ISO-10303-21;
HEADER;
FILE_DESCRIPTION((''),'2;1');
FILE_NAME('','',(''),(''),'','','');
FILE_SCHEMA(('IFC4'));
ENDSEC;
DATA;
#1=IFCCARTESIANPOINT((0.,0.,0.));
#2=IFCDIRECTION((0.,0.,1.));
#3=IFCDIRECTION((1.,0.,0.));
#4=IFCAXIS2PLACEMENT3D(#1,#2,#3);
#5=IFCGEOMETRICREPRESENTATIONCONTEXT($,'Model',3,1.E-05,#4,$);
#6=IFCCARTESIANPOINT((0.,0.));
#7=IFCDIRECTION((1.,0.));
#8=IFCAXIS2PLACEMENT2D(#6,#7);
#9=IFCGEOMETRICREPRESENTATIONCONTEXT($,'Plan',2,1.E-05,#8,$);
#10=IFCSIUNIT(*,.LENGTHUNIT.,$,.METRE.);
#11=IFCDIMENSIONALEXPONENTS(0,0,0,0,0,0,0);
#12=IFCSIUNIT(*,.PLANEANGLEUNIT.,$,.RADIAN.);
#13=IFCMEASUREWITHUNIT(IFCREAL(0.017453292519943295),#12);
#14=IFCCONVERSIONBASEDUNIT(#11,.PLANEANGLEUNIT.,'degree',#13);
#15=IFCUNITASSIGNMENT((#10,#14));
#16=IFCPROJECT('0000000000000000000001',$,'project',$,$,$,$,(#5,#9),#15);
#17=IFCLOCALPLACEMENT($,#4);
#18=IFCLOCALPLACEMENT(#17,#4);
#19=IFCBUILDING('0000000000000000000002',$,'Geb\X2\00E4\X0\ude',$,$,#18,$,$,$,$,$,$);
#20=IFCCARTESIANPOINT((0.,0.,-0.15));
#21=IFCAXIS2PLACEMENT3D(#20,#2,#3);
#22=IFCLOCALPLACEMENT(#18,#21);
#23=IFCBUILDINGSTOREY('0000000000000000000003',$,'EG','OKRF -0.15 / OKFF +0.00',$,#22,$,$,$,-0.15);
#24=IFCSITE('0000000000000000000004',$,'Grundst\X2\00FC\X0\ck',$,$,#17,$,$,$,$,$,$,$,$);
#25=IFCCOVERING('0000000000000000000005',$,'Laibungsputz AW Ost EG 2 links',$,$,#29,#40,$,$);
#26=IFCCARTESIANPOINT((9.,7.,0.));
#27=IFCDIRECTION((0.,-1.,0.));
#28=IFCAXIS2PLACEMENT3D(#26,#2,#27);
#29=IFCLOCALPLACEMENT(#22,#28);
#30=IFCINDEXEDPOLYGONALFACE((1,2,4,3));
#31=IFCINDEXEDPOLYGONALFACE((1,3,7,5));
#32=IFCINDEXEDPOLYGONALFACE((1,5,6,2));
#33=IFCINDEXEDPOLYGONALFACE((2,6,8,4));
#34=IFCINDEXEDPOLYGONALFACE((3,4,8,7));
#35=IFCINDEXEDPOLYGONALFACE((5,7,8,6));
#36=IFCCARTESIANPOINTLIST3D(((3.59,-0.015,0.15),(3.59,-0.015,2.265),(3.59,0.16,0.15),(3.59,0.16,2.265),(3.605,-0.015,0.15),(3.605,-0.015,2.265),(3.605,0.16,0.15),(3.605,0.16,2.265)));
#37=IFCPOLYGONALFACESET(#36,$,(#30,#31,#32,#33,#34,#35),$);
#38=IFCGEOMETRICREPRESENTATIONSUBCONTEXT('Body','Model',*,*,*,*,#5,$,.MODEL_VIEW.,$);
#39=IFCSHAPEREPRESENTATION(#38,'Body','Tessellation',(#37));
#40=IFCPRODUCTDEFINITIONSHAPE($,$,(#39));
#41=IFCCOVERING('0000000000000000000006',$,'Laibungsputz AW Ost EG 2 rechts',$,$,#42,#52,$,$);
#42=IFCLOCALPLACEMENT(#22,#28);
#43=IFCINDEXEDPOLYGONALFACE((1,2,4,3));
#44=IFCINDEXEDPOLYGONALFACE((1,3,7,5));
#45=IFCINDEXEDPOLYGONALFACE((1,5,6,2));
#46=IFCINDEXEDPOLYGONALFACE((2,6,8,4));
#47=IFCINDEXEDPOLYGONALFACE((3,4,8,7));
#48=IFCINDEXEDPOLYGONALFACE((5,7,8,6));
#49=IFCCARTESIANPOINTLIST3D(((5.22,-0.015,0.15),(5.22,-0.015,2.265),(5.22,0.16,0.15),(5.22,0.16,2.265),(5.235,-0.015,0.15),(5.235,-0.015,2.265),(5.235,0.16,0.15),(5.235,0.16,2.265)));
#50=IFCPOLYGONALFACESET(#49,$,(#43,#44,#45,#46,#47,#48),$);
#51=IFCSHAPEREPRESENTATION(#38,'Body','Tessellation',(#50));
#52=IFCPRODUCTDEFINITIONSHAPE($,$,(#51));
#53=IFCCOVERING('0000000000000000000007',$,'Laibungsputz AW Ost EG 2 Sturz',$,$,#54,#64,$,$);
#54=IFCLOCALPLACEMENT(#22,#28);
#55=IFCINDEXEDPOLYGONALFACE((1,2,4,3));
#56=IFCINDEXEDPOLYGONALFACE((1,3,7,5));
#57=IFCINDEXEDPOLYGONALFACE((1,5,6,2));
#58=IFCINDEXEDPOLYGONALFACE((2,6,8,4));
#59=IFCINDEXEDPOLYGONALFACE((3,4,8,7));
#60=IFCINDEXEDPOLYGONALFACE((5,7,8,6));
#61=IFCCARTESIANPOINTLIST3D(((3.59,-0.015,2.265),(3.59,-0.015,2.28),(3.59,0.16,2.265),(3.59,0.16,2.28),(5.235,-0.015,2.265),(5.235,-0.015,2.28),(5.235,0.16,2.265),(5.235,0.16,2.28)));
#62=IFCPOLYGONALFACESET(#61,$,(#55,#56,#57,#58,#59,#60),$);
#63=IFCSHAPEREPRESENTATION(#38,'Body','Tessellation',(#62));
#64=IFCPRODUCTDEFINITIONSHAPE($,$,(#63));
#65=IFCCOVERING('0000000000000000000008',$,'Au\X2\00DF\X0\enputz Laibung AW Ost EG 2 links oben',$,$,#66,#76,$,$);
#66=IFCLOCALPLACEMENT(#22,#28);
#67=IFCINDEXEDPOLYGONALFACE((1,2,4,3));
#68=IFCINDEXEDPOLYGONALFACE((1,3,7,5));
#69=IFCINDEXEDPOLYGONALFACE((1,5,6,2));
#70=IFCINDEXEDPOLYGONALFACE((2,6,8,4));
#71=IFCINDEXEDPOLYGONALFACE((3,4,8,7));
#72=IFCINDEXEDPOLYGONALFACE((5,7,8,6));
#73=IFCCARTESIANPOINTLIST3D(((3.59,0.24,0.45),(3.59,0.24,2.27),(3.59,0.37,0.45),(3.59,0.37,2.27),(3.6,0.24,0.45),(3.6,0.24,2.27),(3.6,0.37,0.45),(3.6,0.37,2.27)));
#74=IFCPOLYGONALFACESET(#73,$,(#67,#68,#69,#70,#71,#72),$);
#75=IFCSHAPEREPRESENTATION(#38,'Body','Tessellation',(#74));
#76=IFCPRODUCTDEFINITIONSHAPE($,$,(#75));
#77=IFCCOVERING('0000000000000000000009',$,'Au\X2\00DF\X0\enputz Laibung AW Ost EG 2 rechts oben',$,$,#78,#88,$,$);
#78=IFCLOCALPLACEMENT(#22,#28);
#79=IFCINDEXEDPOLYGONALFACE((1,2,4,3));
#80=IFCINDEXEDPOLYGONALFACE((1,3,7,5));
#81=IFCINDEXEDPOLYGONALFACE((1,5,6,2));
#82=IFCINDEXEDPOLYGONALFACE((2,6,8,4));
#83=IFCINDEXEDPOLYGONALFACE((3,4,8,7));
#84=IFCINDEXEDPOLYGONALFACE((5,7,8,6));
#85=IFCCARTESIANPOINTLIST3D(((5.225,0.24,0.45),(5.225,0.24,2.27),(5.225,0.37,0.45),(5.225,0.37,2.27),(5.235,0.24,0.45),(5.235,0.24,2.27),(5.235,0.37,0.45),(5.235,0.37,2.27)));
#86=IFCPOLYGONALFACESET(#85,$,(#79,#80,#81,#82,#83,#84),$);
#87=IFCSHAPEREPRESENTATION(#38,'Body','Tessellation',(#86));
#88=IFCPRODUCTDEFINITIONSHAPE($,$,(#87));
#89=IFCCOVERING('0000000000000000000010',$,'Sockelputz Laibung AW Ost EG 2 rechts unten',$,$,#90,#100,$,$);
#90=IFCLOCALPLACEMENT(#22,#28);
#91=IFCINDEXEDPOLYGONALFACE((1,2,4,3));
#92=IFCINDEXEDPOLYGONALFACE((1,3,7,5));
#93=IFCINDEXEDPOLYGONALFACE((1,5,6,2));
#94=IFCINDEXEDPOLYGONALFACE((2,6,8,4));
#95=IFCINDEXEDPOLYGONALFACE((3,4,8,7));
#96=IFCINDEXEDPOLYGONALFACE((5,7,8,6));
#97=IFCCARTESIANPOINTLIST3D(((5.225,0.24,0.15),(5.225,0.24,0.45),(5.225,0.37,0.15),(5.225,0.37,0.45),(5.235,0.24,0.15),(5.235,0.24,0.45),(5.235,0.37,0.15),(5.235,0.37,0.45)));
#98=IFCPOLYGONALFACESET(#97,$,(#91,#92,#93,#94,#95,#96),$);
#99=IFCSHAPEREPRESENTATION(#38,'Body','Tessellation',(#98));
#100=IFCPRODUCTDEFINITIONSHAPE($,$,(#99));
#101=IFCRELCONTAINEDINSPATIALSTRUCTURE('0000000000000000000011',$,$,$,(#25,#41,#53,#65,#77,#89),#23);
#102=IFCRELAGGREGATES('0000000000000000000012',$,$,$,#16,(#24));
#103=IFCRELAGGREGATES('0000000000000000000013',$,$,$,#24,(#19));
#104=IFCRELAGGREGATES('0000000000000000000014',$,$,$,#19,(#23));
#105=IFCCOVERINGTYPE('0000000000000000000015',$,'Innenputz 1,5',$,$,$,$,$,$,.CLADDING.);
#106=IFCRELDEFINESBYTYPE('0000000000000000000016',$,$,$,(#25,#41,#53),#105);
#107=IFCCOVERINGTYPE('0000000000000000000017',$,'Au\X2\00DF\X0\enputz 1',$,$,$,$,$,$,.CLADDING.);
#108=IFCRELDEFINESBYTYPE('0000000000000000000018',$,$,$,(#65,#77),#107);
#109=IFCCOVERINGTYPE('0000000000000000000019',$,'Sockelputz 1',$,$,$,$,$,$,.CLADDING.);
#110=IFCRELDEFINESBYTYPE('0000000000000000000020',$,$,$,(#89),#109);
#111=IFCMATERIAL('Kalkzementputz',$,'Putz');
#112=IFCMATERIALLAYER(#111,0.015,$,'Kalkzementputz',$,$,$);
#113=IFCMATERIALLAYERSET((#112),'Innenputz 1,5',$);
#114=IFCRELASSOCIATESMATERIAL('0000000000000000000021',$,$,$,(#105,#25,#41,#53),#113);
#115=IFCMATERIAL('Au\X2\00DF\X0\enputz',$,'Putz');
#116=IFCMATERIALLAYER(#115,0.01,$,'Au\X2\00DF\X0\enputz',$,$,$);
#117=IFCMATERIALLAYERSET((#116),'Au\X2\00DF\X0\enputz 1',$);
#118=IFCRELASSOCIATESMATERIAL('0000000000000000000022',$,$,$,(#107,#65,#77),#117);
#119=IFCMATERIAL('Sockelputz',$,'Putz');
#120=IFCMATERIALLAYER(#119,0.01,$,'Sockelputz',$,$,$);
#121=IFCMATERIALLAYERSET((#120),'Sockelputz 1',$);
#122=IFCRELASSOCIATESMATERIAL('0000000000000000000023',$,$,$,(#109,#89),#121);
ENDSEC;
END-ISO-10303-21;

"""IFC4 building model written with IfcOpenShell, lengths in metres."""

from ifc_helpers import new_model, entity, si_unit, converted_unit, frame, origin_with_axes, origin_2d_with_axis, place, context, subcontext, project, spatial, polyline, outline, extrude, material, layer, layer_set, layer_usage, type_object, element, save


model = new_model("IFC4")

# Units and contexts
model_context = context("Model", 3, precision=1e-05, world=origin_with_axes())
plan_context = context("Plan", 2, precision=1e-05, world=origin_2d_with_axis())
body_context = subcontext(model_context, "Body", "Model", "MODEL_VIEW")
ifc_project = project(units=[si_unit("LENGTHUNIT", "METRE"), converted_unit("PLANEANGLEUNIT", "degree", entity("IfcReal", 0.017453292519943295), si_unit("PLANEANGLEUNIT", "RADIAN"), dimensions=[0, 0, 0, 0, 0, 0, 0])], contexts=[model_context, plan_context])

# Site, building, storey
site_placement = place(None, origin_with_axes())
site = spatial("IfcSite", under=ifc_project, at=site_placement, Name="Grundstück")
building_placement = place(site_placement, origin_with_axes())
building = spatial("IfcBuilding", under=site, at=building_placement, Name="Gebäude")
storey_placement = place(building_placement, frame((0.0, 0.0, -0.15), z_axis=(0.0, 0.0, 1.0), x_axis=(1.0, 0.0, 0.0)))
storey = spatial("IfcBuildingStorey", under=building, at=storey_placement, Name="EG", Description="OKRF -0.15 / OKFF +0.00", Elevation=-0.15)

# Coverings
ifc_material_1 = material(Name="Kalkzementputz", Category="Putz")
ifc_layer_1 = layer(ifc_material_1, 0.015, Name="Kalkzementputz")
ifc_layer_set_1 = layer_set([ifc_layer_1], Name="Innenputz 1,5")
ifc_layer_usage_1 = layer_usage(ifc_layer_set_1, "AXIS1", "POSITIVE", 3.59)
covering_type_1 = type_object("IfcCoveringType", Name="Innenputz 1,5", PredefinedType="CLADDING", material=ifc_layer_set_1)
covering_1_placement = place(storey_placement, frame((9.0, 7.0, 0.0), z_axis=(0.0, 0.0, 1.0), x_axis=(0.0, -1.0, 0.0)))
element("IfcCovering", 1, at=covering_1_placement, inside=storey, type_object=covering_type_1, material=ifc_layer_usage_1, Name="Laibungsputz AW Ost EG 2 links", context=body_context, shape_type="SweptSolid", body=[
    extrude(outline(polyline([(-0.015, 0.15), (0.16, 0.15), (0.16, 2.265), (-0.015, 2.265), (-0.015, 0.15)])), frame((3.59, 0.0, 0.0), z_axis=(1.0, 0.0, 0.0), x_axis=(0.0, 1.0, 0.0)), (0.0, 0.0, 1.0), 0.015),
])
ifc_layer_usage_2 = layer_usage(ifc_layer_set_1, "AXIS1", "POSITIVE", 5.22)
covering_2_placement = place(storey_placement, frame((9.0, 7.0, 0.0), z_axis=(0.0, 0.0, 1.0), x_axis=(0.0, -1.0, 0.0)))
element("IfcCovering", 2, at=covering_2_placement, inside=storey, type_object=covering_type_1, material=ifc_layer_usage_2, Name="Laibungsputz AW Ost EG 2 rechts", context=body_context, shape_type="SweptSolid", body=[
    extrude(outline(polyline([(-0.015, 0.15), (0.16, 0.15), (0.16, 2.265), (-0.015, 2.265), (-0.015, 0.15)])), frame((5.22, 0.0, 0.0), z_axis=(1.0, 0.0, 0.0), x_axis=(0.0, 1.0, 0.0)), (0.0, 0.0, 1.0), 0.015),
])
ifc_layer_usage_3 = layer_usage(ifc_layer_set_1, "AXIS3", "POSITIVE", 2.265)
covering_3_placement = place(storey_placement, frame((9.0, 7.0, 0.0), z_axis=(0.0, 0.0, 1.0), x_axis=(0.0, -1.0, 0.0)))
element("IfcCovering", 3, at=covering_3_placement, inside=storey, type_object=covering_type_1, material=ifc_layer_usage_3, Name="Laibungsputz AW Ost EG 2 Sturz", context=body_context, shape_type="SweptSolid", body=[
    extrude(outline(polyline([(-0.015, 2.265), (0.16, 2.265), (0.16, 2.28), (-0.015, 2.28), (-0.015, 2.265)])), frame((3.59, 0.0, 0.0), z_axis=(1.0, 0.0, 0.0), x_axis=(0.0, 1.0, 0.0)), (0.0, 0.0, 1.0), 1.645),
])

# Coverings
ifc_material_2 = material(Name="Außenputz", Category="Putz")
ifc_layer_2 = layer(ifc_material_2, 0.01, Name="Außenputz")
ifc_layer_set_2 = layer_set([ifc_layer_2], Name="Außenputz 1")
ifc_layer_usage_4 = layer_usage(ifc_layer_set_2, "AXIS1", "POSITIVE", 3.59)
covering_type_2 = type_object("IfcCoveringType", Name="Außenputz 1", PredefinedType="CLADDING", material=ifc_layer_set_2)
covering_4_placement = place(storey_placement, frame((9.0, 7.0, 0.0), z_axis=(0.0, 0.0, 1.0), x_axis=(0.0, -1.0, 0.0)))
element("IfcCovering", 4, at=covering_4_placement, inside=storey, type_object=covering_type_2, material=ifc_layer_usage_4, Name="Außenputz Laibung AW Ost EG 2 links oben", context=body_context, shape_type="SweptSolid", body=[
    extrude(outline(polyline([(0.24, 0.45), (0.37, 0.45), (0.37, 2.27), (0.24, 2.27), (0.24, 0.45)])), frame((3.59, 0.0, 0.0), z_axis=(1.0, 0.0, 0.0), x_axis=(0.0, 1.0, 0.0)), (0.0, 0.0, 1.0), 0.01),
])
ifc_layer_usage_5 = layer_usage(ifc_layer_set_2, "AXIS1", "POSITIVE", 5.225)
covering_5_placement = place(storey_placement, frame((9.0, 7.0, 0.0), z_axis=(0.0, 0.0, 1.0), x_axis=(0.0, -1.0, 0.0)))
element("IfcCovering", 5, at=covering_5_placement, inside=storey, type_object=covering_type_2, material=ifc_layer_usage_5, Name="Außenputz Laibung AW Ost EG 2 rechts oben", context=body_context, shape_type="SweptSolid", body=[
    extrude(outline(polyline([(0.24, 0.45), (0.37, 0.45), (0.37, 2.27), (0.24, 2.27), (0.24, 0.45)])), frame((5.225, 0.0, 0.0), z_axis=(1.0, 0.0, 0.0), x_axis=(0.0, 1.0, 0.0)), (0.0, 0.0, 1.0), 0.01),
])

# Covering
ifc_material_3 = material(Name="Sockelputz", Category="Putz")
ifc_layer_3 = layer(ifc_material_3, 0.01, Name="Sockelputz")
ifc_layer_set_3 = layer_set([ifc_layer_3], Name="Sockelputz 1")
ifc_layer_usage_6 = layer_usage(ifc_layer_set_3, "AXIS1", "POSITIVE", 5.225)
covering_type_3 = type_object("IfcCoveringType", Name="Sockelputz 1", PredefinedType="CLADDING", material=ifc_layer_set_3)
covering_6_placement = place(storey_placement, frame((9.0, 7.0, 0.0), z_axis=(0.0, 0.0, 1.0), x_axis=(0.0, -1.0, 0.0)))
element("IfcCovering", 6, at=covering_6_placement, inside=storey, type_object=covering_type_3, material=ifc_layer_usage_6, Name="Sockelputz Laibung AW Ost EG 2 rechts unten", context=body_context, shape_type="SweptSolid", body=[
    extrude(outline(polyline([(0.24, 0.15), (0.37, 0.15), (0.37, 0.45), (0.24, 0.45), (0.24, 0.15)])), frame((5.225, 0.0, 0.0), z_axis=(1.0, 0.0, 0.0), x_axis=(0.0, 1.0, 0.0)), (0.0, 0.0, 1.0), 0.01),
])

save(model, "model.ifc")
